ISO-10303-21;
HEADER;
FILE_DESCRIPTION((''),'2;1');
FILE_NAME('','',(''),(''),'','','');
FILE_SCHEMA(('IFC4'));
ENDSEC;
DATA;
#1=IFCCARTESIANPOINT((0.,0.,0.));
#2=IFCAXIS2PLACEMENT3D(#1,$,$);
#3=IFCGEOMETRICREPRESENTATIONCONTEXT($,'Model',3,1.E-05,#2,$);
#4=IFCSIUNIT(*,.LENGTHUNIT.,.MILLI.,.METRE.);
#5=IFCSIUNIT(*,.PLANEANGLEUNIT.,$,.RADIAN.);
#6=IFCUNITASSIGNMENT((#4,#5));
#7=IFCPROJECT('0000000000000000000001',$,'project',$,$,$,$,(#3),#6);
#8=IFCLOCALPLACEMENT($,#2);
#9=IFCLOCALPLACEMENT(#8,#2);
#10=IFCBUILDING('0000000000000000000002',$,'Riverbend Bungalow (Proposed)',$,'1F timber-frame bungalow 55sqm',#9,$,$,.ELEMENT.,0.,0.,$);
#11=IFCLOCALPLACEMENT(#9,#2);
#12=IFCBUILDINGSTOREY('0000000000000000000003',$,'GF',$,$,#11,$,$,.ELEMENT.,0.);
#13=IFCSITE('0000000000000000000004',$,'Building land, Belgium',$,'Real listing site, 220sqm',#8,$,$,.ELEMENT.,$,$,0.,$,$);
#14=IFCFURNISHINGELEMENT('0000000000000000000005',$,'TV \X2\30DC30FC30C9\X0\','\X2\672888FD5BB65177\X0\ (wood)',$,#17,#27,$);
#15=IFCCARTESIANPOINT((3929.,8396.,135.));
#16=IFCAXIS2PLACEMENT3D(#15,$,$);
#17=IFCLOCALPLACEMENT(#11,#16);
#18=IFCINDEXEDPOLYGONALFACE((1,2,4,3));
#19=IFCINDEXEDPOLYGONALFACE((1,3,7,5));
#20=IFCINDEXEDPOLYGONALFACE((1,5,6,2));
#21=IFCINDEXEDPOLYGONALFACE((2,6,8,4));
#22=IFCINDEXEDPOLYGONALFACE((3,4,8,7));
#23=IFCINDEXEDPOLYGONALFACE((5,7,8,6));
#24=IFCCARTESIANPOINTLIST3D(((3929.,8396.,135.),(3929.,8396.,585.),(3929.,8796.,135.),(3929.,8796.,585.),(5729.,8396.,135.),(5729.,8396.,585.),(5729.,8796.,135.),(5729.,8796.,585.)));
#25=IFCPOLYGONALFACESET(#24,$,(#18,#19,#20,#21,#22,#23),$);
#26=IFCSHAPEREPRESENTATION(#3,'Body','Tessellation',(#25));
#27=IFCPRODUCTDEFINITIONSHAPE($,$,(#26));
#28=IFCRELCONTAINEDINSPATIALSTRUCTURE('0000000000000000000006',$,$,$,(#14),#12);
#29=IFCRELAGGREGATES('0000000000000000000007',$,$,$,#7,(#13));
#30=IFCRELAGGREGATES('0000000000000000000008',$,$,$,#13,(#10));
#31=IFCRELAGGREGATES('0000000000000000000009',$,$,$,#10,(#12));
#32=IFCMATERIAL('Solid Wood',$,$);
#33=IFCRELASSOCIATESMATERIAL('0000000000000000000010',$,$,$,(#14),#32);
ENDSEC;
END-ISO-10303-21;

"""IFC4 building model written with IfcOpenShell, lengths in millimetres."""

from ifc_helpers import new_model, si_unit, frame, frame_2d, origin, place, context, project, spatial, rectangle, extrude, material, element, save


model = new_model("IFC4")

# Units and contexts
model_context = context("Model", 3, precision=1e-05, world=origin())
ifc_project = project(units=[si_unit("LENGTHUNIT", "METRE", prefix="MILLI"), si_unit("PLANEANGLEUNIT", "RADIAN")], contexts=[model_context])

# Site, building, storey
site_placement = place(None, origin())
site = spatial("IfcSite", under=ifc_project, at=site_placement, Name="Building land, Belgium", ObjectType="Real listing site, 220sqm", CompositionType="ELEMENT", RefElevation=0.0)
building_placement = place(site_placement, origin())
building = spatial("IfcBuilding", under=site, at=building_placement, Name="Riverbend Bungalow (Proposed)", ObjectType="1F timber-frame bungalow 55sqm", CompositionType="ELEMENT", ElevationOfRefHeight=0.0, ElevationOfTerrain=0.0)
storey_placement = place(building_placement, origin())
storey = spatial("IfcBuildingStorey", under=building, at=storey_placement, Name="GF", CompositionType="ELEMENT", Elevation=0.0)

# Shared definitions
ifc_material_1 = material(Name="Solid Wood")

# Furnishing element
furnishing_placement = place(storey_placement, frame((3929.0, 8396.0, 135.0)))
element("IfcFurnishingElement", 1, at=furnishing_placement, inside=storey, material=ifc_material_1, Name="TV ボード", Description="木製家具 (wood)", context=model_context, shape_type="SweptSolid", body=[
    extrude(rectangle(XDim=1800.0, YDim=400.0, at=frame_2d((900.0, 200.0))), frame((3929.0, 8396.0, 135.0)), (0.0, 0.0, 1.0), 450.0),
])

save(model, "model.ifc")
